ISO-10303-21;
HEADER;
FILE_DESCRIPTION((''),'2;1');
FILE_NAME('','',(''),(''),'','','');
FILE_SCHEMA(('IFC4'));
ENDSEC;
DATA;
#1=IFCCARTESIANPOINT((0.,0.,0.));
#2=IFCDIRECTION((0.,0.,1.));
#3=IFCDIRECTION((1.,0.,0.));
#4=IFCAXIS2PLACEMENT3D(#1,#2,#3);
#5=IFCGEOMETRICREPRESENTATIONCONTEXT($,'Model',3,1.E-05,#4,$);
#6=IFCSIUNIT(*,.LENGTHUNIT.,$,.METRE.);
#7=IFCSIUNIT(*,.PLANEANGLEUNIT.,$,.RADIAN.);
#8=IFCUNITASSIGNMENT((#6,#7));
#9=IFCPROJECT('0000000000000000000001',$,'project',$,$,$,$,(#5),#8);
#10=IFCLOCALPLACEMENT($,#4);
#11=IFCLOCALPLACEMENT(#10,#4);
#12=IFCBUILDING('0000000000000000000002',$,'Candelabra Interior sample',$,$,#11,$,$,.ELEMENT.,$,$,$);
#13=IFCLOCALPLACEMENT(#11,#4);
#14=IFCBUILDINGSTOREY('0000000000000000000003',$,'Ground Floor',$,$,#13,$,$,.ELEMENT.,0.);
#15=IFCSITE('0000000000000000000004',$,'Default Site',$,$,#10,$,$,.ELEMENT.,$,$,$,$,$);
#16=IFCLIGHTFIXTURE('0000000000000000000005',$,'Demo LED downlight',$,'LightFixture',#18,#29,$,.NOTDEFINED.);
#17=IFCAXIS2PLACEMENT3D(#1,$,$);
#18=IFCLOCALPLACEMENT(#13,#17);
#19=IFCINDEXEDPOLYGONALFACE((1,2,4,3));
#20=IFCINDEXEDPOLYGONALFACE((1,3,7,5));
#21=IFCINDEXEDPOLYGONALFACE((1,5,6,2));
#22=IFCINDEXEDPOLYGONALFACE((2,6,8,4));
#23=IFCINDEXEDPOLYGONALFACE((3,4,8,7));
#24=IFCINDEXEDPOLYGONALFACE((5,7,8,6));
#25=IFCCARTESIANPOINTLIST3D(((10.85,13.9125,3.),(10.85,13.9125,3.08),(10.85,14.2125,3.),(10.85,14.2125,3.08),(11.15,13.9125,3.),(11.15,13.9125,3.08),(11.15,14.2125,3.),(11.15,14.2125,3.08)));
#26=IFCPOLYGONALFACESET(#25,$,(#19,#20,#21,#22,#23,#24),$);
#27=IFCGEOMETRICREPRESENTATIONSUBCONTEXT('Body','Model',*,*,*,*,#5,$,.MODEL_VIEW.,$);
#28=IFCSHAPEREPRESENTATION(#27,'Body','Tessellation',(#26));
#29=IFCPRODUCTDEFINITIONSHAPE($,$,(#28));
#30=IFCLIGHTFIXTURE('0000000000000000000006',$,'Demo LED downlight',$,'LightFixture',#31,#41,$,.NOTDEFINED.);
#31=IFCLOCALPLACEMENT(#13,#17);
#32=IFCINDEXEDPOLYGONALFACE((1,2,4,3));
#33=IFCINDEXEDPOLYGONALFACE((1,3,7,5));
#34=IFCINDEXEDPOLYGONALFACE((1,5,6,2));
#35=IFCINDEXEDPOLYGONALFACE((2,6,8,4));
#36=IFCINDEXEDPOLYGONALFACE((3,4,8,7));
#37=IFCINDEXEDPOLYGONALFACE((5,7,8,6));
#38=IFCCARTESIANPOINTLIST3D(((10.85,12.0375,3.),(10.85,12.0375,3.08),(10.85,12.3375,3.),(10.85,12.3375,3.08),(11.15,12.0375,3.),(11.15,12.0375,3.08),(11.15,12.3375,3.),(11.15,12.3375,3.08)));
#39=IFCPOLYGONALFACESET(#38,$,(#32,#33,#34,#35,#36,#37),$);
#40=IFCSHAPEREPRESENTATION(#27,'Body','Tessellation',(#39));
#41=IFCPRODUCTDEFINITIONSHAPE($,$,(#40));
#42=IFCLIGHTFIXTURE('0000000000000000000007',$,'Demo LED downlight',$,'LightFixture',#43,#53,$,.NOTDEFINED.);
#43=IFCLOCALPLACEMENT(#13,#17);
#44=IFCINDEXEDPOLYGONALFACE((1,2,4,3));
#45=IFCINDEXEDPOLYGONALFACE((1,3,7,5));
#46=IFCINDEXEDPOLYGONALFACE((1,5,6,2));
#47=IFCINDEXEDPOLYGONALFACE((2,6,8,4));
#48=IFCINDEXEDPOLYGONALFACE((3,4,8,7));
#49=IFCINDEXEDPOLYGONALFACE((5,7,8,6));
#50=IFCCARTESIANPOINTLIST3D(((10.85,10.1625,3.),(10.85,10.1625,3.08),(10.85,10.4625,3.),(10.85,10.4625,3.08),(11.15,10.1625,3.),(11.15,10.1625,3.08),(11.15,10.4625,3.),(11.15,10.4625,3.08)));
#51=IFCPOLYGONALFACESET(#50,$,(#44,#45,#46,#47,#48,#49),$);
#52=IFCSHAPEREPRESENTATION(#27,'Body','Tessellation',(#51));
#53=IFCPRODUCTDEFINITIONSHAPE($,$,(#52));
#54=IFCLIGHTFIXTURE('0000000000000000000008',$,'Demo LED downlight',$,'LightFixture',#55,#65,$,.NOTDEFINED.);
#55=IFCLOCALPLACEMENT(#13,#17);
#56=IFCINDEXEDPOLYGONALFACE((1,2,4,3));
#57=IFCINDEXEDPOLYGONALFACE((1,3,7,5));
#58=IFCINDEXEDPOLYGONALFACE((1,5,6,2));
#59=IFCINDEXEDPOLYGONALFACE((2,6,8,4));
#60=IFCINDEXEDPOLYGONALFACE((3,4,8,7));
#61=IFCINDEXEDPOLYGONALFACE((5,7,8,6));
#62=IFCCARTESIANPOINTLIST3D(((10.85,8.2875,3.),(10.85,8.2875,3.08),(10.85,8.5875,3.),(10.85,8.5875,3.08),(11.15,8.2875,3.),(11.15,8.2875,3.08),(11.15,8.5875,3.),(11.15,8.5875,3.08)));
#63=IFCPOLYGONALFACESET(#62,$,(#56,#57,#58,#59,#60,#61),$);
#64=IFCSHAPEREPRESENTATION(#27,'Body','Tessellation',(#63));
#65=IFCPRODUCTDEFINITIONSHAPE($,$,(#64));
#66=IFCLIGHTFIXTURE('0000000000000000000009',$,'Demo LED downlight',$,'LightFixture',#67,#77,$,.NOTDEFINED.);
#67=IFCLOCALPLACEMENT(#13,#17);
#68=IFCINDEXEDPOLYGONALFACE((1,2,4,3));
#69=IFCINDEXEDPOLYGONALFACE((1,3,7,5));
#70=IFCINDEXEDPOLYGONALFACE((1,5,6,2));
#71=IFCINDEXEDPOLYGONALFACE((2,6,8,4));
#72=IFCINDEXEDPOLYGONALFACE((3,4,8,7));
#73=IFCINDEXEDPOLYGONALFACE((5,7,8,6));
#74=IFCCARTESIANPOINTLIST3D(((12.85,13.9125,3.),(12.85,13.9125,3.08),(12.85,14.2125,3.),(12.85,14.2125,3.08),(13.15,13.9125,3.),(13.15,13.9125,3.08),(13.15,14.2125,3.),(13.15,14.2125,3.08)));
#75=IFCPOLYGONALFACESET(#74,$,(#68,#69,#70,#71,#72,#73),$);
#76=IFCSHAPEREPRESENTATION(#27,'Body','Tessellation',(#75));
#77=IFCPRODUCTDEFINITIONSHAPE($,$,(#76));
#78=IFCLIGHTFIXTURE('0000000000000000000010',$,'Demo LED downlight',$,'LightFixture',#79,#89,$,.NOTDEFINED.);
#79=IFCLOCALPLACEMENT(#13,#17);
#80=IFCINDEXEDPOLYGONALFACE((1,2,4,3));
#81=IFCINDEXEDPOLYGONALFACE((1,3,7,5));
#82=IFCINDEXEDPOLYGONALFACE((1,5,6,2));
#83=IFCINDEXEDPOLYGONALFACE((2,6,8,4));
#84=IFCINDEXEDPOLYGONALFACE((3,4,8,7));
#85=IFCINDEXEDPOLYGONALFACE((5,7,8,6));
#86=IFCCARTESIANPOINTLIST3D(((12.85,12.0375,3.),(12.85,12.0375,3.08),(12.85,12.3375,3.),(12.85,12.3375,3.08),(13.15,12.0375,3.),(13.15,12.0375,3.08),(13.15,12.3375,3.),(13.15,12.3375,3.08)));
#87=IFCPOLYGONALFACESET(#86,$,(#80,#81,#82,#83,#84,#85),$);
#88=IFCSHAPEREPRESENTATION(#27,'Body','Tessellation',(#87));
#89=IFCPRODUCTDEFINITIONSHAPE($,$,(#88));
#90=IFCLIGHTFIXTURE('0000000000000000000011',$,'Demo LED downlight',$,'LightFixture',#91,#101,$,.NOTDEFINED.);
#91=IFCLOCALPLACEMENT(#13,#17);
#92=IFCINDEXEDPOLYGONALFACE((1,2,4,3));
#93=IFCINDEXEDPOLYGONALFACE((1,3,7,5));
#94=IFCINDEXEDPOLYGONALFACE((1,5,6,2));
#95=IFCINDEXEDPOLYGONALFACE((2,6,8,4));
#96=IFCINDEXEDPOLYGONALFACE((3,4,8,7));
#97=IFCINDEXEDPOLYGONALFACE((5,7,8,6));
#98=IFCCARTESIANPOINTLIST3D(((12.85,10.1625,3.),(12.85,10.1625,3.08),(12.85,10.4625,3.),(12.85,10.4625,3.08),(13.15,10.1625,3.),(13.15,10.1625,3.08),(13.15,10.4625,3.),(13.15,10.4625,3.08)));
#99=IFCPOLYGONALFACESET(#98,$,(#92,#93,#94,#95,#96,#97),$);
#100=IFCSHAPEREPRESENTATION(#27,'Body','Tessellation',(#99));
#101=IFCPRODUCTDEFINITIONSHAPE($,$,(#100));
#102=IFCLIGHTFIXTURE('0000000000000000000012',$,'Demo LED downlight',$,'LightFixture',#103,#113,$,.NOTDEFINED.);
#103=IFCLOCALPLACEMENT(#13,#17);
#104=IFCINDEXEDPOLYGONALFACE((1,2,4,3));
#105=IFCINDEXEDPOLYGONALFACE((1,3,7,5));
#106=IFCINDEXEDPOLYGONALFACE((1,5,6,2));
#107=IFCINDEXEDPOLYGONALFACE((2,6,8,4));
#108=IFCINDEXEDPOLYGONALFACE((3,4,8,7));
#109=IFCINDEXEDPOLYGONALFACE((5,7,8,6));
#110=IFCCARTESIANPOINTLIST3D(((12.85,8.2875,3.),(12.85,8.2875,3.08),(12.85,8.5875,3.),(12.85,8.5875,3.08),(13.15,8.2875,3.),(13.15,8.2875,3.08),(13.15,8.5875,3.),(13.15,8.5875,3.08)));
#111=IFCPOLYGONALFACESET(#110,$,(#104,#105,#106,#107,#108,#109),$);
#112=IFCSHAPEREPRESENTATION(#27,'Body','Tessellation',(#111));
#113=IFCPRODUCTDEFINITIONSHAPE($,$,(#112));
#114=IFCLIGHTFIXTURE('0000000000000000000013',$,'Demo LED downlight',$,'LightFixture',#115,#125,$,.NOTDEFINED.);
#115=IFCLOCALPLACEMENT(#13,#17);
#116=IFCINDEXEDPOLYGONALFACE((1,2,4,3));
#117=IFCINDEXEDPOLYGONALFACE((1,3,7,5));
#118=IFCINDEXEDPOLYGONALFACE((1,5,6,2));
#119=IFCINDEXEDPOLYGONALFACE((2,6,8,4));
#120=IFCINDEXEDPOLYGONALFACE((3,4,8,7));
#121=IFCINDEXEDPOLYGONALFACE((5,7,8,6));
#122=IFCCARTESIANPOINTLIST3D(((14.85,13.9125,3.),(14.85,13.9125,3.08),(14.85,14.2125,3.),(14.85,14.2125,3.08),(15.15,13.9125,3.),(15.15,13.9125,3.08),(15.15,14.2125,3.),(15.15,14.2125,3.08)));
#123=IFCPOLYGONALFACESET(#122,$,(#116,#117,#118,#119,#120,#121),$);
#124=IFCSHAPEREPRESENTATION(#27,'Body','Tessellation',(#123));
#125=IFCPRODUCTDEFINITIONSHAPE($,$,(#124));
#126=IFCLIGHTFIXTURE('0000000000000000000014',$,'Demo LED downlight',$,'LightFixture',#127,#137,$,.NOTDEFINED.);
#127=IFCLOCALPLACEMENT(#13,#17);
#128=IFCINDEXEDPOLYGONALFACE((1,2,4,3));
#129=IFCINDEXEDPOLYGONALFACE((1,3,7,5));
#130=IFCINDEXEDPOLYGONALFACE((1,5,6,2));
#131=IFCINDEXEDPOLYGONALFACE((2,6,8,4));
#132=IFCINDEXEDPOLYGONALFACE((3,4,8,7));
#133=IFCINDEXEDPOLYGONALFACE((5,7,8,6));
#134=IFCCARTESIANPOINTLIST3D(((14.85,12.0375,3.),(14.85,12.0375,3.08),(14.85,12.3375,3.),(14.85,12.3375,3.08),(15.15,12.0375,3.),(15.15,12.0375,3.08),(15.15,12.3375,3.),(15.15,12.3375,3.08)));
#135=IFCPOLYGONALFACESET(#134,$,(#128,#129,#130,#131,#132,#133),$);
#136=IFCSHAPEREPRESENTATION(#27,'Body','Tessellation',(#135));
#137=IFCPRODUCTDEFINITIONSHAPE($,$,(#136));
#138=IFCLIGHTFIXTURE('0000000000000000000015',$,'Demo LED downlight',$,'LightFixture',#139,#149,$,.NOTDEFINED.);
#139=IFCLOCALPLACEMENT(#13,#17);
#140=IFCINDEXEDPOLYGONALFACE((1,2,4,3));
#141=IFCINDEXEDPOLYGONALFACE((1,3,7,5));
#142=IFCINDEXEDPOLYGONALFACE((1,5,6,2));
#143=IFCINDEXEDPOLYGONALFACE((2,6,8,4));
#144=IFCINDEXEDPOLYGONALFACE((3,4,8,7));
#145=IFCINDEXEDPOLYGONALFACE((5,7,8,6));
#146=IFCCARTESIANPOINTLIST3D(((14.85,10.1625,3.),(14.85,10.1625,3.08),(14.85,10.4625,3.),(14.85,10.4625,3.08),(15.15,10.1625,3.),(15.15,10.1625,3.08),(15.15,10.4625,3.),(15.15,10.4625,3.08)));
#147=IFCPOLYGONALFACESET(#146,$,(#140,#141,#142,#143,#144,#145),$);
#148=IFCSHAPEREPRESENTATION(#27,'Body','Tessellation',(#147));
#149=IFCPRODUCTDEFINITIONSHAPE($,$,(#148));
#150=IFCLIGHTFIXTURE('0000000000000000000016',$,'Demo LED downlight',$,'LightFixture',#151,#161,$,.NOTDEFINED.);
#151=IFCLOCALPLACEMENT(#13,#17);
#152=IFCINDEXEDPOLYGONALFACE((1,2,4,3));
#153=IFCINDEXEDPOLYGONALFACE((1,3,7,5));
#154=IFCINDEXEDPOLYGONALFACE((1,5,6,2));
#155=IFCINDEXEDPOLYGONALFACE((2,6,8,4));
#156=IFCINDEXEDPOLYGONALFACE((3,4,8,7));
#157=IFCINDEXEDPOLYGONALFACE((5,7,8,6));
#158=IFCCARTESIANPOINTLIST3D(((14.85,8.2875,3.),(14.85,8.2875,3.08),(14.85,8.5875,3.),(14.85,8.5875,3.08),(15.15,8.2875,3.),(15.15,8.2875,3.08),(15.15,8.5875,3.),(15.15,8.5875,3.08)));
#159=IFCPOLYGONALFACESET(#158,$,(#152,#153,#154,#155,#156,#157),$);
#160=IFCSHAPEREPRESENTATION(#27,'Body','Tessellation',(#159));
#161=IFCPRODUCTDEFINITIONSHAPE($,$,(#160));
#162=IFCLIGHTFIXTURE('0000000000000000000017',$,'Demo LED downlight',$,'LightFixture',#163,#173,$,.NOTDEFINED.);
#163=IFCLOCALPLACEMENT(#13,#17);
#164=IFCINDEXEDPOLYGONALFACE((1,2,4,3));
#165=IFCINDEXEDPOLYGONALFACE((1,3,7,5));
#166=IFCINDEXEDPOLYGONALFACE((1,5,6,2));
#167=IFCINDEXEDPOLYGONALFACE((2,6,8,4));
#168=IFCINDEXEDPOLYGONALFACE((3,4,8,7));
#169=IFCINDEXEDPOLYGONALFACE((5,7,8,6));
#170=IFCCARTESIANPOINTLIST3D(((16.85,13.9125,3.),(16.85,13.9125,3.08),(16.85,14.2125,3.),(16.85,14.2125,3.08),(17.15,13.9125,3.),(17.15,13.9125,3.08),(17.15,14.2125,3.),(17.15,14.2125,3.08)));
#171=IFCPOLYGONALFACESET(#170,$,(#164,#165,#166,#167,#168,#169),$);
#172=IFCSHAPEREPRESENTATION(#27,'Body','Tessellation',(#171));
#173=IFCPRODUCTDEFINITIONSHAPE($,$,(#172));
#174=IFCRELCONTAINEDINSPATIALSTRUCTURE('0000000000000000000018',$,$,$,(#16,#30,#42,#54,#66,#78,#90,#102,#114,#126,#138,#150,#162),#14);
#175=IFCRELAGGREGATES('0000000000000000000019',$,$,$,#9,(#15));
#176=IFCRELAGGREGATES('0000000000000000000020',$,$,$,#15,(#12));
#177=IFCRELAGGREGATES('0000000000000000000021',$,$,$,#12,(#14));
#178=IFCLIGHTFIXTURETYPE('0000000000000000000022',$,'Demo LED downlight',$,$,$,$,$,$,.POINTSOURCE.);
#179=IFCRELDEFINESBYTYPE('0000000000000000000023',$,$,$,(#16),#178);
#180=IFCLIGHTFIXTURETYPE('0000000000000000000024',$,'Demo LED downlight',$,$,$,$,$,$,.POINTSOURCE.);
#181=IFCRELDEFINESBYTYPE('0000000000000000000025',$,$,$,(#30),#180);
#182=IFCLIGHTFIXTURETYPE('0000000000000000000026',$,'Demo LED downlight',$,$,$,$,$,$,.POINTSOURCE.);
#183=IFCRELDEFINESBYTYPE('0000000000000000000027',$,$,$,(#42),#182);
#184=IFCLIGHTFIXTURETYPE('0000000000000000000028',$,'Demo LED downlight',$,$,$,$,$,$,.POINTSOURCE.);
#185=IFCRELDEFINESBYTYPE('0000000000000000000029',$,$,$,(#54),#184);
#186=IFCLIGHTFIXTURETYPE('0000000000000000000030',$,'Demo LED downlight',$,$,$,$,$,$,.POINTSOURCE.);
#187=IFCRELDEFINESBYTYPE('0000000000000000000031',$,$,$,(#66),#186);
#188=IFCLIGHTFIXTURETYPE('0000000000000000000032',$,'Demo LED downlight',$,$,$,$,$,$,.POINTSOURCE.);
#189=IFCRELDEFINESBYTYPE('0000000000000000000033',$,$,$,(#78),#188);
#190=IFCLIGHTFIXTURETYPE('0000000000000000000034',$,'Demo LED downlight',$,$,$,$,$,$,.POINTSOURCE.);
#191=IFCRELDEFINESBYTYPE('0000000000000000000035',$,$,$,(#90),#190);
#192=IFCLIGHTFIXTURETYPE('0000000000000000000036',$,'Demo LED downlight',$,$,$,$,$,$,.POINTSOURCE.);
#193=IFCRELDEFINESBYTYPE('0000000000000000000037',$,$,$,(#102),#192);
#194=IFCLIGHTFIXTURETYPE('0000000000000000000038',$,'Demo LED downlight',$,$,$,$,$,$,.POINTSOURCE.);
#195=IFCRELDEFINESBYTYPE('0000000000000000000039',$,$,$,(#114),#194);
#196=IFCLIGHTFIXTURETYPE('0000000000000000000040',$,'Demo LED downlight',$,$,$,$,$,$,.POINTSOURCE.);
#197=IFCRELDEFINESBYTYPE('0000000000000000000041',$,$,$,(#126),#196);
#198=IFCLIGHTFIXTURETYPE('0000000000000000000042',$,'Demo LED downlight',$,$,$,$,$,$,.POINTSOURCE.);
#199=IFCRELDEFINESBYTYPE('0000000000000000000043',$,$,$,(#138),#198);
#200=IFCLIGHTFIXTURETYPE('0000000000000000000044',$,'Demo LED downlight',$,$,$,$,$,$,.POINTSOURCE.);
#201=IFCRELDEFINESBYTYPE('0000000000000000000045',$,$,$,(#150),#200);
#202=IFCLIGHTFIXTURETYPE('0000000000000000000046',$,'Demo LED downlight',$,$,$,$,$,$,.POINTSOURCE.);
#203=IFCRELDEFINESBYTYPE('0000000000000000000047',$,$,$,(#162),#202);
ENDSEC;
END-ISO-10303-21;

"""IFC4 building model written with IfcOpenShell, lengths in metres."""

from ifc_helpers import new_model, si_unit, frame, origin_with_axes, place, context, subcontext, project, spatial, polyline, outline, extrude, type_object, element, save


model = new_model("IFC4")

# Units and contexts
model_context = context("Model", 3, precision=1e-05, world=origin_with_axes())
body_context = subcontext(model_context, "Body", "Model", "MODEL_VIEW")
ifc_project = project(units=[si_unit("LENGTHUNIT", "METRE"), si_unit("PLANEANGLEUNIT", "RADIAN")], contexts=[model_context])

# Site, building, storey
site_placement = place(None, origin_with_axes())
site = spatial("IfcSite", under=ifc_project, at=site_placement, Name="Default Site", CompositionType="ELEMENT")
building_placement = place(site_placement, origin_with_axes())
building = spatial("IfcBuilding", under=site, at=building_placement, Name="Candelabra Interior sample", CompositionType="ELEMENT")
storey_placement = place(building_placement, origin_with_axes())
storey = spatial("IfcBuildingStorey", under=building, at=storey_placement, Name="Ground Floor", CompositionType="ELEMENT", Elevation=0.0)

# Light fixtures
light_fixture_type_1 = type_object("IfcLightFixtureType", Name="Demo LED downlight", PredefinedType="POINTSOURCE")
light_fixture_1_placement = place(storey_placement, frame((11.0, 14.0625, 3.08), z_axis=(0.0, 0.0, 1.0), x_axis=(1.0, 0.0, 0.0)))
element("IfcLightFixture", 1, at=light_fixture_1_placement, inside=storey, type_object=light_fixture_type_1, Name="Demo LED downlight", ObjectType="LightFixture", PredefinedType="NOTDEFINED", context=body_context, shape_type="SweptSolid", body=[
    extrude(outline(polyline([(0.15, 0.15), (-0.15, 0.15), (-0.15, -0.15), (0.15, -0.15), (0.15, 0.15)])), origin_with_axes(), (0.0, 0.0, -1.0), 0.08),
])
light_fixture_type_2 = type_object("IfcLightFixtureType", Name="Demo LED downlight", PredefinedType="POINTSOURCE")
light_fixture_2_placement = place(storey_placement, frame((11.0, 12.1875, 3.08), z_axis=(0.0, 0.0, 1.0), x_axis=(1.0, 0.0, 0.0)))
element("IfcLightFixture", 2, at=light_fixture_2_placement, inside=storey, type_object=light_fixture_type_2, Name="Demo LED downlight", ObjectType="LightFixture", PredefinedType="NOTDEFINED", context=body_context, shape_type="SweptSolid", body=[
    extrude(outline(polyline([(0.15, 0.15), (-0.15, 0.15), (-0.15, -0.15), (0.15, -0.15), (0.15, 0.15)])), origin_with_axes(), (0.0, 0.0, -1.0), 0.08),
])
light_fixture_type_3 = type_object("IfcLightFixtureType", Name="Demo LED downlight", PredefinedType="POINTSOURCE")
light_fixture_3_placement = place(storey_placement, frame((11.0, 10.3125, 3.08), z_axis=(0.0, 0.0, 1.0), x_axis=(1.0, 0.0, 0.0)))
element("IfcLightFixture", 3, at=light_fixture_3_placement, inside=storey, type_object=light_fixture_type_3, Name="Demo LED downlight", ObjectType="LightFixture", PredefinedType="NOTDEFINED", context=body_context, shape_type="SweptSolid", body=[
    extrude(outline(polyline([(0.15, 0.15), (-0.15, 0.15), (-0.15, -0.15), (0.15, -0.15), (0.15, 0.15)])), origin_with_axes(), (0.0, 0.0, -1.0), 0.08),
])
light_fixture_type_4 = type_object("IfcLightFixtureType", Name="Demo LED downlight", PredefinedType="POINTSOURCE")
light_fixture_4_placement = place(storey_placement, frame((11.0, 8.4375, 3.08), z_axis=(0.0, 0.0, 1.0), x_axis=(1.0, 0.0, 0.0)))
element("IfcLightFixture", 4, at=light_fixture_4_placement, inside=storey, type_object=light_fixture_type_4, Name="Demo LED downlight", ObjectType="LightFixture", PredefinedType="NOTDEFINED", context=body_context, shape_type="SweptSolid", body=[
    extrude(outline(polyline([(0.15, 0.15), (-0.15, 0.15), (-0.15, -0.15), (0.15, -0.15), (0.15, 0.15)])), origin_with_axes(), (0.0, 0.0, -1.0), 0.08),
])
light_fixture_type_5 = type_object("IfcLightFixtureType", Name="Demo LED downlight", PredefinedType="POINTSOURCE")
light_fixture_5_placement = place(storey_placement, frame((13.0, 14.0625, 3.08), z_axis=(0.0, 0.0, 1.0), x_axis=(1.0, 0.0, 0.0)))
element("IfcLightFixture", 5, at=light_fixture_5_placement, inside=storey, type_object=light_fixture_type_5, Name="Demo LED downlight", ObjectType="LightFixture", PredefinedType="NOTDEFINED", context=body_context, shape_type="SweptSolid", body=[
    extrude(outline(polyline([(0.15, 0.15), (-0.15, 0.15), (-0.15, -0.15), (0.15, -0.15), (0.15, 0.15)])), origin_with_axes(), (0.0, 0.0, -1.0), 0.08),
])
light_fixture_type_6 = type_object("IfcLightFixtureType", Name="Demo LED downlight", PredefinedType="POINTSOURCE")
light_fixture_6_placement = place(storey_placement, frame((13.0, 12.1875, 3.08), z_axis=(0.0, 0.0, 1.0), x_axis=(1.0, 0.0, 0.0)))
element("IfcLightFixture", 6, at=light_fixture_6_placement, inside=storey, type_object=light_fixture_type_6, Name="Demo LED downlight", ObjectType="LightFixture", PredefinedType="NOTDEFINED", context=body_context, shape_type="SweptSolid", body=[
    extrude(outline(polyline([(0.15, 0.15), (-0.15, 0.15), (-0.15, -0.15), (0.15, -0.15), (0.15, 0.15)])), origin_with_axes(), (0.0, 0.0, -1.0), 0.08),
])
light_fixture_type_7 = type_object("IfcLightFixtureType", Name="Demo LED downlight", PredefinedType="POINTSOURCE")
light_fixture_7_placement = place(storey_placement, frame((13.0, 10.3125, 3.08), z_axis=(0.0, 0.0, 1.0), x_axis=(1.0, 0.0, 0.0)))
element("IfcLightFixture", 7, at=light_fixture_7_placement, inside=storey, type_object=light_fixture_type_7, Name="Demo LED downlight", ObjectType="LightFixture", PredefinedType="NOTDEFINED", context=body_context, shape_type="SweptSolid", body=[
    extrude(outline(polyline([(0.15, 0.15), (-0.15, 0.15), (-0.15, -0.15), (0.15, -0.15), (0.15, 0.15)])), origin_with_axes(), (0.0, 0.0, -1.0), 0.08),
])
light_fixture_type_8 = type_object("IfcLightFixtureType", Name="Demo LED downlight", PredefinedType="POINTSOURCE")
light_fixture_8_placement = place(storey_placement, frame((13.0, 8.4375, 3.08), z_axis=(0.0, 0.0, 1.0), x_axis=(1.0, 0.0, 0.0)))
element("IfcLightFixture", 8, at=light_fixture_8_placement, inside=storey, type_object=light_fixture_type_8, Name="Demo LED downlight", ObjectType="LightFixture", PredefinedType="NOTDEFINED", context=body_context, shape_type="SweptSolid", body=[
    extrude(outline(polyline([(0.15, 0.15), (-0.15, 0.15), (-0.15, -0.15), (0.15, -0.15), (0.15, 0.15)])), origin_with_axes(), (0.0, 0.0, -1.0), 0.08),
])
light_fixture_type_9 = type_object("IfcLightFixtureType", Name="Demo LED downlight", PredefinedType="POINTSOURCE")
light_fixture_9_placement = place(storey_placement, frame((15.0, 14.0625, 3.08), z_axis=(0.0, 0.0, 1.0), x_axis=(1.0, 0.0, 0.0)))
element("IfcLightFixture", 9, at=light_fixture_9_placement, inside=storey, type_object=light_fixture_type_9, Name="Demo LED downlight", ObjectType="LightFixture", PredefinedType="NOTDEFINED", context=body_context, shape_type="SweptSolid", body=[
    extrude(outline(polyline([(0.15, 0.15), (-0.15, 0.15), (-0.15, -0.15), (0.15, -0.15), (0.15, 0.15)])), origin_with_axes(), (0.0, 0.0, -1.0), 0.08),
])
light_fixture_type_10 = type_object("IfcLightFixtureType", Name="Demo LED downlight", PredefinedType="POINTSOURCE")
light_fixture_10_placement = place(storey_placement, frame((15.0, 12.1875, 3.08), z_axis=(0.0, 0.0, 1.0), x_axis=(1.0, 0.0, 0.0)))
element("IfcLightFixture", 10, at=light_fixture_10_placement, inside=storey, type_object=light_fixture_type_10, Name="Demo LED downlight", ObjectType="LightFixture", PredefinedType="NOTDEFINED", context=body_context, shape_type="SweptSolid", body=[
    extrude(outline(polyline([(0.15, 0.15), (-0.15, 0.15), (-0.15, -0.15), (0.15, -0.15), (0.15, 0.15)])), origin_with_axes(), (0.0, 0.0, -1.0), 0.08),
])
light_fixture_type_11 = type_object("IfcLightFixtureType", Name="Demo LED downlight", PredefinedType="POINTSOURCE")
light_fixture_11_placement = place(storey_placement, frame((15.0, 10.3125, 3.08), z_axis=(0.0, 0.0, 1.0), x_axis=(1.0, 0.0, 0.0)))
element("IfcLightFixture", 11, at=light_fixture_11_placement, inside=storey, type_object=light_fixture_type_11, Name="Demo LED downlight", ObjectType="LightFixture", PredefinedType="NOTDEFINED", context=body_context, shape_type="SweptSolid", body=[
    extrude(outline(polyline([(0.15, 0.15), (-0.15, 0.15), (-0.15, -0.15), (0.15, -0.15), (0.15, 0.15)])), origin_with_axes(), (0.0, 0.0, -1.0), 0.08),
])
light_fixture_type_12 = type_object("IfcLightFixtureType", Name="Demo LED downlight", PredefinedType="POINTSOURCE")
light_fixture_12_placement = place(storey_placement, frame((15.0, 8.4375, 3.08), z_axis=(0.0, 0.0, 1.0), x_axis=(1.0, 0.0, 0.0)))
element("IfcLightFixture", 12, at=light_fixture_12_placement, inside=storey, type_object=light_fixture_type_12, Name="Demo LED downlight", ObjectType="LightFixture", PredefinedType="NOTDEFINED", context=body_context, shape_type="SweptSolid", body=[
    extrude(outline(polyline([(0.15, 0.15), (-0.15, 0.15), (-0.15, -0.15), (0.15, -0.15), (0.15, 0.15)])), origin_with_axes(), (0.0, 0.0, -1.0), 0.08),
])
light_fixture_type_13 = type_object("IfcLightFixtureType", Name="Demo LED downlight", PredefinedType="POINTSOURCE")
light_fixture_13_placement = place(storey_placement, frame((17.0, 14.0625, 3.08), z_axis=(0.0, 0.0, 1.0), x_axis=(1.0, 0.0, 0.0)))
element("IfcLightFixture", 13, at=light_fixture_13_placement, inside=storey, type_object=light_fixture_type_13, Name="Demo LED downlight", ObjectType="LightFixture", PredefinedType="NOTDEFINED", context=body_context, shape_type="SweptSolid", body=[
    extrude(outline(polyline([(0.15, 0.15), (-0.15, 0.15), (-0.15, -0.15), (0.15, -0.15), (0.15, 0.15)])), origin_with_axes(), (0.0, 0.0, -1.0), 0.08),
])

save(model, "model.ifc")
